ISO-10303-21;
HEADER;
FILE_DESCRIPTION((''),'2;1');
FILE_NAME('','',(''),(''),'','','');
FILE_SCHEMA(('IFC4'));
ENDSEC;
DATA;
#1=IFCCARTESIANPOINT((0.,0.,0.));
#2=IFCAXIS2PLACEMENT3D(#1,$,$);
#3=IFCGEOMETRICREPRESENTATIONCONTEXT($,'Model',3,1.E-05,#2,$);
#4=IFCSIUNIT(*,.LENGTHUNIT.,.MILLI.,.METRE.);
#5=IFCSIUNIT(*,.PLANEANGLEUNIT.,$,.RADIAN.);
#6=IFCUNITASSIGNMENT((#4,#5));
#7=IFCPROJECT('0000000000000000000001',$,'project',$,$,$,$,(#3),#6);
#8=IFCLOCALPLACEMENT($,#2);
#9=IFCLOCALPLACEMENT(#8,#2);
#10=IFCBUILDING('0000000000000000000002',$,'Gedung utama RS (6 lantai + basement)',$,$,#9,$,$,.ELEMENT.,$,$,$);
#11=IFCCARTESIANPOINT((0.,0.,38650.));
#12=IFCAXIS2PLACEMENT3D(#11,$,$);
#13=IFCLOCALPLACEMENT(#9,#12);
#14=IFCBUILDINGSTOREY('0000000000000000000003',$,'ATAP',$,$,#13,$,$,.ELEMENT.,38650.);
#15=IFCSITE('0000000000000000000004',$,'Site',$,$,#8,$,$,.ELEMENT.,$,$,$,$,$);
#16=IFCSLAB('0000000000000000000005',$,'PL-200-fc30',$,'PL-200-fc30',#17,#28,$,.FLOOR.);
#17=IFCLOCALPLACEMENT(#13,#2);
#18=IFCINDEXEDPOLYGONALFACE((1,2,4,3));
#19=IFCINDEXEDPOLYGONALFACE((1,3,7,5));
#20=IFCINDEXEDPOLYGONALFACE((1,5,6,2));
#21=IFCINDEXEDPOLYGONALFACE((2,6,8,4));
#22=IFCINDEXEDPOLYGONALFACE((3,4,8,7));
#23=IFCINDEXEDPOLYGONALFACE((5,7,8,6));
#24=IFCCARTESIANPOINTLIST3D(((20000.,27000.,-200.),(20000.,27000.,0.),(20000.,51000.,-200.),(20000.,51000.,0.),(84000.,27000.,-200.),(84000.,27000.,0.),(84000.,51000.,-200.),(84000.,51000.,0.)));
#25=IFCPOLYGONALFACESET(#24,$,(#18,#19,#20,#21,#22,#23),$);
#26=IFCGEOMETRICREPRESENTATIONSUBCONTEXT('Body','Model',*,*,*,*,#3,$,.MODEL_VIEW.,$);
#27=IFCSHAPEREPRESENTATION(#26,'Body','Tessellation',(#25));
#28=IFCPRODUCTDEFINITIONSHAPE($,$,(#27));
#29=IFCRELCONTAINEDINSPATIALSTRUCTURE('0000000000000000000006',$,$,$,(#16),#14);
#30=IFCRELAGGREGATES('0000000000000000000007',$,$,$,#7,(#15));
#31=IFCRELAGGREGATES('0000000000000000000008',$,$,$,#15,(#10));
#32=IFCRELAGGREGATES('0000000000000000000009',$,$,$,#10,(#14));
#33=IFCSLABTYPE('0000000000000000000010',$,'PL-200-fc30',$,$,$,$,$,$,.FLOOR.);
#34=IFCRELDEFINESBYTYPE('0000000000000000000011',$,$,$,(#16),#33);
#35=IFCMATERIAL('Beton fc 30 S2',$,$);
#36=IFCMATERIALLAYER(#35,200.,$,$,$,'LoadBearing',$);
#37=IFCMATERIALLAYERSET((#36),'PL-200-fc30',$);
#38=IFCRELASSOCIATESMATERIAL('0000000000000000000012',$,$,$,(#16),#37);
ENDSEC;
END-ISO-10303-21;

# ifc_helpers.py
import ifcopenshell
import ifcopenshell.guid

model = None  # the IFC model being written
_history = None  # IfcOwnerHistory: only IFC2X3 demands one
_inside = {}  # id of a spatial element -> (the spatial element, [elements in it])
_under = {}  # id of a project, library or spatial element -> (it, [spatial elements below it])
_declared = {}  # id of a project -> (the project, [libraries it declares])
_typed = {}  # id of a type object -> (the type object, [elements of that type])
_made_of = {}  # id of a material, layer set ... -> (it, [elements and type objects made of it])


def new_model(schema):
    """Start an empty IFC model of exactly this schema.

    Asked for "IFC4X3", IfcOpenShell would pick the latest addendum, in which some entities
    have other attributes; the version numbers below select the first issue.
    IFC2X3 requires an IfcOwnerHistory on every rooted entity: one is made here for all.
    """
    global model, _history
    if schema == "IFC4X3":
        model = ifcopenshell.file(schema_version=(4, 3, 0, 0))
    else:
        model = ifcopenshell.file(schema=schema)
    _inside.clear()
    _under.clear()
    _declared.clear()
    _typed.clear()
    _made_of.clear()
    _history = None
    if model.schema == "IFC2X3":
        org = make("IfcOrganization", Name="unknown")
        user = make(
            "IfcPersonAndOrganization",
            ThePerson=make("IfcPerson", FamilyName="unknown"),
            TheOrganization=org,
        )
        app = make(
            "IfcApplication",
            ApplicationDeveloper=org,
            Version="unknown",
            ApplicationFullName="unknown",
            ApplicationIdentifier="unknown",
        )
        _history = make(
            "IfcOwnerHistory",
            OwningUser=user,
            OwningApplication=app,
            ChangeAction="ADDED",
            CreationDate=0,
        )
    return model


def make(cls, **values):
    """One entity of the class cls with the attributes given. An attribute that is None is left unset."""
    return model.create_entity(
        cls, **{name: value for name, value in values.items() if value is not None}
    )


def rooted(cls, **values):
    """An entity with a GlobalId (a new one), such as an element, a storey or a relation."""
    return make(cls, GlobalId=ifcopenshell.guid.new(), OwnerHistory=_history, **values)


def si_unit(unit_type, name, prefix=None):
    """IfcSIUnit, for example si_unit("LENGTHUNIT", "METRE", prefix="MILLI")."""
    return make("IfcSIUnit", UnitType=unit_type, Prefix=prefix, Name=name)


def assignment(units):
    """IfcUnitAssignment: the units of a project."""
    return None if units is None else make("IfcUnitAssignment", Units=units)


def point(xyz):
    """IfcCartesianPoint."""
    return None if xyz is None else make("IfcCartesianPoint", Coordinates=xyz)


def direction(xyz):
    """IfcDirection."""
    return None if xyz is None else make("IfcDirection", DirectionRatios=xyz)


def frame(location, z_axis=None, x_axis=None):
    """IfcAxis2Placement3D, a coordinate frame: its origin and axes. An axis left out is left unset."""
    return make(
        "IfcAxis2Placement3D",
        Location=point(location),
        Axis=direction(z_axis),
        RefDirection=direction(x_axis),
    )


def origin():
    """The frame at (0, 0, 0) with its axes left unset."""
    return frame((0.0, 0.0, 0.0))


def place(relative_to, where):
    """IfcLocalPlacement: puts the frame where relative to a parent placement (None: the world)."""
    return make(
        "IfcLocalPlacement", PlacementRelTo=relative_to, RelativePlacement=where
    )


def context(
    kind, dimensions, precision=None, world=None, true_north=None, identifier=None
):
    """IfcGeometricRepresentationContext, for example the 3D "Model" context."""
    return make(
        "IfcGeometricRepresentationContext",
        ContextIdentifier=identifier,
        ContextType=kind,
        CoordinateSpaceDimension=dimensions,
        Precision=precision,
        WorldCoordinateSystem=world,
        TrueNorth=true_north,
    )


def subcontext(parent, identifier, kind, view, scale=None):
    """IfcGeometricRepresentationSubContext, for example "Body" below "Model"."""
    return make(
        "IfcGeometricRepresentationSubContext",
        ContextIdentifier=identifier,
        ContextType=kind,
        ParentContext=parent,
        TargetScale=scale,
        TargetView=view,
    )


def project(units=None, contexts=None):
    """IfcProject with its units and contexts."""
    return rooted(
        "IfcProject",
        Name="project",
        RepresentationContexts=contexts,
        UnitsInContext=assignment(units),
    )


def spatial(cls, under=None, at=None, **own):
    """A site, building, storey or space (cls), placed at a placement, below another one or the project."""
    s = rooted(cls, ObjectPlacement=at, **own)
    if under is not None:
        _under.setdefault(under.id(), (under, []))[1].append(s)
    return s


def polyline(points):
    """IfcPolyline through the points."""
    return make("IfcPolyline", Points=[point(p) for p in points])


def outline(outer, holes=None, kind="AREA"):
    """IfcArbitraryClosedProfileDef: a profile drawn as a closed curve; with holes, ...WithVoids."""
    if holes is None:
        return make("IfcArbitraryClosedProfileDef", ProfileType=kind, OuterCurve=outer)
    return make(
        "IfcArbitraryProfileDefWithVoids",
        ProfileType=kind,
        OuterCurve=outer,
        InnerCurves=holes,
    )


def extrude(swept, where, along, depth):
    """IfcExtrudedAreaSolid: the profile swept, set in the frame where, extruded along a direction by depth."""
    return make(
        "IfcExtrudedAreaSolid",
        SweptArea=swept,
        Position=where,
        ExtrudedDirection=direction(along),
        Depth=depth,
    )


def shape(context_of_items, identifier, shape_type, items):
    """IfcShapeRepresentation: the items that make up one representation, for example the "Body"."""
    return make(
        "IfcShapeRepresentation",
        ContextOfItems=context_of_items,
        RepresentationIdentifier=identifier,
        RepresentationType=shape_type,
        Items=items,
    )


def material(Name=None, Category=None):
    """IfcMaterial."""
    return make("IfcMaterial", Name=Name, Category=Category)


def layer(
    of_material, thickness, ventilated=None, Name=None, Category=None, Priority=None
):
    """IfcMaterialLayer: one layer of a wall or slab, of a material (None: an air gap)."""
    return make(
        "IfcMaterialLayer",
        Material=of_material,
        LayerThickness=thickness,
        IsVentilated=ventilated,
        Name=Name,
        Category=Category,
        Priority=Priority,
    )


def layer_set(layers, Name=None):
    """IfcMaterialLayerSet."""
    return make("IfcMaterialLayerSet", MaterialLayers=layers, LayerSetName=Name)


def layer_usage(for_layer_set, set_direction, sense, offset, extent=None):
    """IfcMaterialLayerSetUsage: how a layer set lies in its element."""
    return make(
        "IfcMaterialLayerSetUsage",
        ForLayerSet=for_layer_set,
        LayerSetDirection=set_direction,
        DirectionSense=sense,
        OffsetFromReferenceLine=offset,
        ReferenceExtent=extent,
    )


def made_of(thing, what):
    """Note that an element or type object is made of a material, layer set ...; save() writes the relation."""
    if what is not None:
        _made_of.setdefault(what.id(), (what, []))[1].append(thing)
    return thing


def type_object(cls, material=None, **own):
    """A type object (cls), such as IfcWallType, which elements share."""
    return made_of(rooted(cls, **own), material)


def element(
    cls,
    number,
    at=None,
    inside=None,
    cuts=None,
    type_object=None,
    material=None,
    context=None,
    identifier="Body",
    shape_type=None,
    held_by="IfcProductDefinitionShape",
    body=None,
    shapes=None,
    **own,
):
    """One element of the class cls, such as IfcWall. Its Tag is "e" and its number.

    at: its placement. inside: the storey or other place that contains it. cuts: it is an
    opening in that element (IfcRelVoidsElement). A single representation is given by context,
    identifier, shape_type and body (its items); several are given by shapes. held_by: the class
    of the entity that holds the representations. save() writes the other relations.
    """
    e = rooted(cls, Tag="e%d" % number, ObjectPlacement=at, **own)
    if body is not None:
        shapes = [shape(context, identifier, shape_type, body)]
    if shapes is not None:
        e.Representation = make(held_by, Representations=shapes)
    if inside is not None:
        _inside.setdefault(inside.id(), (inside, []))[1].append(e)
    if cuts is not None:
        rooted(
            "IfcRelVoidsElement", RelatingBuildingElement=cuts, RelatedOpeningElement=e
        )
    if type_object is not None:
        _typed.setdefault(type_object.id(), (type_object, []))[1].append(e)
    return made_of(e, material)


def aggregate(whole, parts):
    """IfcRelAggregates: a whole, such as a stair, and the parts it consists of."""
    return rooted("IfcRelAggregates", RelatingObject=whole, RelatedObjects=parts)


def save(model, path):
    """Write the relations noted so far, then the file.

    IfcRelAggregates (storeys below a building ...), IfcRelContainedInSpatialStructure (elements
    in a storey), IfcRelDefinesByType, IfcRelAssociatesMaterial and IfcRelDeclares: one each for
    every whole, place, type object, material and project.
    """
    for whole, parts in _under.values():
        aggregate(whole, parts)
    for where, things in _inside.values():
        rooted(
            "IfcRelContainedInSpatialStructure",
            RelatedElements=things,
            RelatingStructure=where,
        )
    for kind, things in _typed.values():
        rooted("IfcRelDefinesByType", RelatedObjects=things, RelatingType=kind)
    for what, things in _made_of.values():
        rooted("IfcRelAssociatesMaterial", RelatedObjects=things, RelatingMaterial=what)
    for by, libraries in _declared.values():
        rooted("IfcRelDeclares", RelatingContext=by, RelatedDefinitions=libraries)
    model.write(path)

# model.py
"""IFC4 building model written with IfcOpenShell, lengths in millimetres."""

from ifc_helpers import new_model, si_unit, frame, origin, place, context, subcontext, project, spatial, polyline, outline, extrude, material, layer, layer_set, layer_usage, type_object, element, save


model = new_model("IFC4")

# Units and contexts
model_context = context("Model", 3, precision=1e-05, world=origin())
body_context = subcontext(model_context, "Body", "Model", "MODEL_VIEW")
ifc_project = project(units=[si_unit("LENGTHUNIT", "METRE", prefix="MILLI"), si_unit("PLANEANGLEUNIT", "RADIAN")], contexts=[model_context])

# Site, building, storey
site_placement = place(None, origin())
site = spatial("IfcSite", under=ifc_project, at=site_placement, Name="Site", CompositionType="ELEMENT")
building_placement = place(site_placement, origin())
building = spatial("IfcBuilding", under=site, at=building_placement, Name="Gedung utama RS (6 lantai + basement)", CompositionType="ELEMENT")
storey_placement = place(building_placement, frame((0.0, 0.0, 38650.0)))
storey = spatial("IfcBuildingStorey", under=building, at=storey_placement, Name="ATAP", CompositionType="ELEMENT", Elevation=38650.0)

# Slab
ifc_material = material(Name="Beton fc 30 S2")
ifc_layer = layer(ifc_material, 200.0, Category="LoadBearing")
ifc_layer_set = layer_set([ifc_layer], Name="PL-200-fc30")
ifc_layer_usage = layer_usage(ifc_layer_set, "AXIS3", "NEGATIVE", 0.0)
slab_type = type_object("IfcSlabType", Name="PL-200-fc30", PredefinedType="FLOOR")
slab_placement = place(storey_placement, origin())
element("IfcSlab", 1, at=slab_placement, inside=storey, type_object=slab_type, material=ifc_layer_usage, Name="PL-200-fc30", ObjectType="PL-200-fc30", PredefinedType="FLOOR", context=body_context, shape_type="SweptSolid", body=[
    extrude(outline(polyline([(20000.0, 27000.0), (84000.0, 27000.0), (84000.0, 51000.0), (20000.0, 51000.0), (20000.0, 27000.0)])), frame((0.0, 0.0, -200.0)), (0.0, 0.0, 1.0), 200.0),
])

save(model, "model.ifc")
